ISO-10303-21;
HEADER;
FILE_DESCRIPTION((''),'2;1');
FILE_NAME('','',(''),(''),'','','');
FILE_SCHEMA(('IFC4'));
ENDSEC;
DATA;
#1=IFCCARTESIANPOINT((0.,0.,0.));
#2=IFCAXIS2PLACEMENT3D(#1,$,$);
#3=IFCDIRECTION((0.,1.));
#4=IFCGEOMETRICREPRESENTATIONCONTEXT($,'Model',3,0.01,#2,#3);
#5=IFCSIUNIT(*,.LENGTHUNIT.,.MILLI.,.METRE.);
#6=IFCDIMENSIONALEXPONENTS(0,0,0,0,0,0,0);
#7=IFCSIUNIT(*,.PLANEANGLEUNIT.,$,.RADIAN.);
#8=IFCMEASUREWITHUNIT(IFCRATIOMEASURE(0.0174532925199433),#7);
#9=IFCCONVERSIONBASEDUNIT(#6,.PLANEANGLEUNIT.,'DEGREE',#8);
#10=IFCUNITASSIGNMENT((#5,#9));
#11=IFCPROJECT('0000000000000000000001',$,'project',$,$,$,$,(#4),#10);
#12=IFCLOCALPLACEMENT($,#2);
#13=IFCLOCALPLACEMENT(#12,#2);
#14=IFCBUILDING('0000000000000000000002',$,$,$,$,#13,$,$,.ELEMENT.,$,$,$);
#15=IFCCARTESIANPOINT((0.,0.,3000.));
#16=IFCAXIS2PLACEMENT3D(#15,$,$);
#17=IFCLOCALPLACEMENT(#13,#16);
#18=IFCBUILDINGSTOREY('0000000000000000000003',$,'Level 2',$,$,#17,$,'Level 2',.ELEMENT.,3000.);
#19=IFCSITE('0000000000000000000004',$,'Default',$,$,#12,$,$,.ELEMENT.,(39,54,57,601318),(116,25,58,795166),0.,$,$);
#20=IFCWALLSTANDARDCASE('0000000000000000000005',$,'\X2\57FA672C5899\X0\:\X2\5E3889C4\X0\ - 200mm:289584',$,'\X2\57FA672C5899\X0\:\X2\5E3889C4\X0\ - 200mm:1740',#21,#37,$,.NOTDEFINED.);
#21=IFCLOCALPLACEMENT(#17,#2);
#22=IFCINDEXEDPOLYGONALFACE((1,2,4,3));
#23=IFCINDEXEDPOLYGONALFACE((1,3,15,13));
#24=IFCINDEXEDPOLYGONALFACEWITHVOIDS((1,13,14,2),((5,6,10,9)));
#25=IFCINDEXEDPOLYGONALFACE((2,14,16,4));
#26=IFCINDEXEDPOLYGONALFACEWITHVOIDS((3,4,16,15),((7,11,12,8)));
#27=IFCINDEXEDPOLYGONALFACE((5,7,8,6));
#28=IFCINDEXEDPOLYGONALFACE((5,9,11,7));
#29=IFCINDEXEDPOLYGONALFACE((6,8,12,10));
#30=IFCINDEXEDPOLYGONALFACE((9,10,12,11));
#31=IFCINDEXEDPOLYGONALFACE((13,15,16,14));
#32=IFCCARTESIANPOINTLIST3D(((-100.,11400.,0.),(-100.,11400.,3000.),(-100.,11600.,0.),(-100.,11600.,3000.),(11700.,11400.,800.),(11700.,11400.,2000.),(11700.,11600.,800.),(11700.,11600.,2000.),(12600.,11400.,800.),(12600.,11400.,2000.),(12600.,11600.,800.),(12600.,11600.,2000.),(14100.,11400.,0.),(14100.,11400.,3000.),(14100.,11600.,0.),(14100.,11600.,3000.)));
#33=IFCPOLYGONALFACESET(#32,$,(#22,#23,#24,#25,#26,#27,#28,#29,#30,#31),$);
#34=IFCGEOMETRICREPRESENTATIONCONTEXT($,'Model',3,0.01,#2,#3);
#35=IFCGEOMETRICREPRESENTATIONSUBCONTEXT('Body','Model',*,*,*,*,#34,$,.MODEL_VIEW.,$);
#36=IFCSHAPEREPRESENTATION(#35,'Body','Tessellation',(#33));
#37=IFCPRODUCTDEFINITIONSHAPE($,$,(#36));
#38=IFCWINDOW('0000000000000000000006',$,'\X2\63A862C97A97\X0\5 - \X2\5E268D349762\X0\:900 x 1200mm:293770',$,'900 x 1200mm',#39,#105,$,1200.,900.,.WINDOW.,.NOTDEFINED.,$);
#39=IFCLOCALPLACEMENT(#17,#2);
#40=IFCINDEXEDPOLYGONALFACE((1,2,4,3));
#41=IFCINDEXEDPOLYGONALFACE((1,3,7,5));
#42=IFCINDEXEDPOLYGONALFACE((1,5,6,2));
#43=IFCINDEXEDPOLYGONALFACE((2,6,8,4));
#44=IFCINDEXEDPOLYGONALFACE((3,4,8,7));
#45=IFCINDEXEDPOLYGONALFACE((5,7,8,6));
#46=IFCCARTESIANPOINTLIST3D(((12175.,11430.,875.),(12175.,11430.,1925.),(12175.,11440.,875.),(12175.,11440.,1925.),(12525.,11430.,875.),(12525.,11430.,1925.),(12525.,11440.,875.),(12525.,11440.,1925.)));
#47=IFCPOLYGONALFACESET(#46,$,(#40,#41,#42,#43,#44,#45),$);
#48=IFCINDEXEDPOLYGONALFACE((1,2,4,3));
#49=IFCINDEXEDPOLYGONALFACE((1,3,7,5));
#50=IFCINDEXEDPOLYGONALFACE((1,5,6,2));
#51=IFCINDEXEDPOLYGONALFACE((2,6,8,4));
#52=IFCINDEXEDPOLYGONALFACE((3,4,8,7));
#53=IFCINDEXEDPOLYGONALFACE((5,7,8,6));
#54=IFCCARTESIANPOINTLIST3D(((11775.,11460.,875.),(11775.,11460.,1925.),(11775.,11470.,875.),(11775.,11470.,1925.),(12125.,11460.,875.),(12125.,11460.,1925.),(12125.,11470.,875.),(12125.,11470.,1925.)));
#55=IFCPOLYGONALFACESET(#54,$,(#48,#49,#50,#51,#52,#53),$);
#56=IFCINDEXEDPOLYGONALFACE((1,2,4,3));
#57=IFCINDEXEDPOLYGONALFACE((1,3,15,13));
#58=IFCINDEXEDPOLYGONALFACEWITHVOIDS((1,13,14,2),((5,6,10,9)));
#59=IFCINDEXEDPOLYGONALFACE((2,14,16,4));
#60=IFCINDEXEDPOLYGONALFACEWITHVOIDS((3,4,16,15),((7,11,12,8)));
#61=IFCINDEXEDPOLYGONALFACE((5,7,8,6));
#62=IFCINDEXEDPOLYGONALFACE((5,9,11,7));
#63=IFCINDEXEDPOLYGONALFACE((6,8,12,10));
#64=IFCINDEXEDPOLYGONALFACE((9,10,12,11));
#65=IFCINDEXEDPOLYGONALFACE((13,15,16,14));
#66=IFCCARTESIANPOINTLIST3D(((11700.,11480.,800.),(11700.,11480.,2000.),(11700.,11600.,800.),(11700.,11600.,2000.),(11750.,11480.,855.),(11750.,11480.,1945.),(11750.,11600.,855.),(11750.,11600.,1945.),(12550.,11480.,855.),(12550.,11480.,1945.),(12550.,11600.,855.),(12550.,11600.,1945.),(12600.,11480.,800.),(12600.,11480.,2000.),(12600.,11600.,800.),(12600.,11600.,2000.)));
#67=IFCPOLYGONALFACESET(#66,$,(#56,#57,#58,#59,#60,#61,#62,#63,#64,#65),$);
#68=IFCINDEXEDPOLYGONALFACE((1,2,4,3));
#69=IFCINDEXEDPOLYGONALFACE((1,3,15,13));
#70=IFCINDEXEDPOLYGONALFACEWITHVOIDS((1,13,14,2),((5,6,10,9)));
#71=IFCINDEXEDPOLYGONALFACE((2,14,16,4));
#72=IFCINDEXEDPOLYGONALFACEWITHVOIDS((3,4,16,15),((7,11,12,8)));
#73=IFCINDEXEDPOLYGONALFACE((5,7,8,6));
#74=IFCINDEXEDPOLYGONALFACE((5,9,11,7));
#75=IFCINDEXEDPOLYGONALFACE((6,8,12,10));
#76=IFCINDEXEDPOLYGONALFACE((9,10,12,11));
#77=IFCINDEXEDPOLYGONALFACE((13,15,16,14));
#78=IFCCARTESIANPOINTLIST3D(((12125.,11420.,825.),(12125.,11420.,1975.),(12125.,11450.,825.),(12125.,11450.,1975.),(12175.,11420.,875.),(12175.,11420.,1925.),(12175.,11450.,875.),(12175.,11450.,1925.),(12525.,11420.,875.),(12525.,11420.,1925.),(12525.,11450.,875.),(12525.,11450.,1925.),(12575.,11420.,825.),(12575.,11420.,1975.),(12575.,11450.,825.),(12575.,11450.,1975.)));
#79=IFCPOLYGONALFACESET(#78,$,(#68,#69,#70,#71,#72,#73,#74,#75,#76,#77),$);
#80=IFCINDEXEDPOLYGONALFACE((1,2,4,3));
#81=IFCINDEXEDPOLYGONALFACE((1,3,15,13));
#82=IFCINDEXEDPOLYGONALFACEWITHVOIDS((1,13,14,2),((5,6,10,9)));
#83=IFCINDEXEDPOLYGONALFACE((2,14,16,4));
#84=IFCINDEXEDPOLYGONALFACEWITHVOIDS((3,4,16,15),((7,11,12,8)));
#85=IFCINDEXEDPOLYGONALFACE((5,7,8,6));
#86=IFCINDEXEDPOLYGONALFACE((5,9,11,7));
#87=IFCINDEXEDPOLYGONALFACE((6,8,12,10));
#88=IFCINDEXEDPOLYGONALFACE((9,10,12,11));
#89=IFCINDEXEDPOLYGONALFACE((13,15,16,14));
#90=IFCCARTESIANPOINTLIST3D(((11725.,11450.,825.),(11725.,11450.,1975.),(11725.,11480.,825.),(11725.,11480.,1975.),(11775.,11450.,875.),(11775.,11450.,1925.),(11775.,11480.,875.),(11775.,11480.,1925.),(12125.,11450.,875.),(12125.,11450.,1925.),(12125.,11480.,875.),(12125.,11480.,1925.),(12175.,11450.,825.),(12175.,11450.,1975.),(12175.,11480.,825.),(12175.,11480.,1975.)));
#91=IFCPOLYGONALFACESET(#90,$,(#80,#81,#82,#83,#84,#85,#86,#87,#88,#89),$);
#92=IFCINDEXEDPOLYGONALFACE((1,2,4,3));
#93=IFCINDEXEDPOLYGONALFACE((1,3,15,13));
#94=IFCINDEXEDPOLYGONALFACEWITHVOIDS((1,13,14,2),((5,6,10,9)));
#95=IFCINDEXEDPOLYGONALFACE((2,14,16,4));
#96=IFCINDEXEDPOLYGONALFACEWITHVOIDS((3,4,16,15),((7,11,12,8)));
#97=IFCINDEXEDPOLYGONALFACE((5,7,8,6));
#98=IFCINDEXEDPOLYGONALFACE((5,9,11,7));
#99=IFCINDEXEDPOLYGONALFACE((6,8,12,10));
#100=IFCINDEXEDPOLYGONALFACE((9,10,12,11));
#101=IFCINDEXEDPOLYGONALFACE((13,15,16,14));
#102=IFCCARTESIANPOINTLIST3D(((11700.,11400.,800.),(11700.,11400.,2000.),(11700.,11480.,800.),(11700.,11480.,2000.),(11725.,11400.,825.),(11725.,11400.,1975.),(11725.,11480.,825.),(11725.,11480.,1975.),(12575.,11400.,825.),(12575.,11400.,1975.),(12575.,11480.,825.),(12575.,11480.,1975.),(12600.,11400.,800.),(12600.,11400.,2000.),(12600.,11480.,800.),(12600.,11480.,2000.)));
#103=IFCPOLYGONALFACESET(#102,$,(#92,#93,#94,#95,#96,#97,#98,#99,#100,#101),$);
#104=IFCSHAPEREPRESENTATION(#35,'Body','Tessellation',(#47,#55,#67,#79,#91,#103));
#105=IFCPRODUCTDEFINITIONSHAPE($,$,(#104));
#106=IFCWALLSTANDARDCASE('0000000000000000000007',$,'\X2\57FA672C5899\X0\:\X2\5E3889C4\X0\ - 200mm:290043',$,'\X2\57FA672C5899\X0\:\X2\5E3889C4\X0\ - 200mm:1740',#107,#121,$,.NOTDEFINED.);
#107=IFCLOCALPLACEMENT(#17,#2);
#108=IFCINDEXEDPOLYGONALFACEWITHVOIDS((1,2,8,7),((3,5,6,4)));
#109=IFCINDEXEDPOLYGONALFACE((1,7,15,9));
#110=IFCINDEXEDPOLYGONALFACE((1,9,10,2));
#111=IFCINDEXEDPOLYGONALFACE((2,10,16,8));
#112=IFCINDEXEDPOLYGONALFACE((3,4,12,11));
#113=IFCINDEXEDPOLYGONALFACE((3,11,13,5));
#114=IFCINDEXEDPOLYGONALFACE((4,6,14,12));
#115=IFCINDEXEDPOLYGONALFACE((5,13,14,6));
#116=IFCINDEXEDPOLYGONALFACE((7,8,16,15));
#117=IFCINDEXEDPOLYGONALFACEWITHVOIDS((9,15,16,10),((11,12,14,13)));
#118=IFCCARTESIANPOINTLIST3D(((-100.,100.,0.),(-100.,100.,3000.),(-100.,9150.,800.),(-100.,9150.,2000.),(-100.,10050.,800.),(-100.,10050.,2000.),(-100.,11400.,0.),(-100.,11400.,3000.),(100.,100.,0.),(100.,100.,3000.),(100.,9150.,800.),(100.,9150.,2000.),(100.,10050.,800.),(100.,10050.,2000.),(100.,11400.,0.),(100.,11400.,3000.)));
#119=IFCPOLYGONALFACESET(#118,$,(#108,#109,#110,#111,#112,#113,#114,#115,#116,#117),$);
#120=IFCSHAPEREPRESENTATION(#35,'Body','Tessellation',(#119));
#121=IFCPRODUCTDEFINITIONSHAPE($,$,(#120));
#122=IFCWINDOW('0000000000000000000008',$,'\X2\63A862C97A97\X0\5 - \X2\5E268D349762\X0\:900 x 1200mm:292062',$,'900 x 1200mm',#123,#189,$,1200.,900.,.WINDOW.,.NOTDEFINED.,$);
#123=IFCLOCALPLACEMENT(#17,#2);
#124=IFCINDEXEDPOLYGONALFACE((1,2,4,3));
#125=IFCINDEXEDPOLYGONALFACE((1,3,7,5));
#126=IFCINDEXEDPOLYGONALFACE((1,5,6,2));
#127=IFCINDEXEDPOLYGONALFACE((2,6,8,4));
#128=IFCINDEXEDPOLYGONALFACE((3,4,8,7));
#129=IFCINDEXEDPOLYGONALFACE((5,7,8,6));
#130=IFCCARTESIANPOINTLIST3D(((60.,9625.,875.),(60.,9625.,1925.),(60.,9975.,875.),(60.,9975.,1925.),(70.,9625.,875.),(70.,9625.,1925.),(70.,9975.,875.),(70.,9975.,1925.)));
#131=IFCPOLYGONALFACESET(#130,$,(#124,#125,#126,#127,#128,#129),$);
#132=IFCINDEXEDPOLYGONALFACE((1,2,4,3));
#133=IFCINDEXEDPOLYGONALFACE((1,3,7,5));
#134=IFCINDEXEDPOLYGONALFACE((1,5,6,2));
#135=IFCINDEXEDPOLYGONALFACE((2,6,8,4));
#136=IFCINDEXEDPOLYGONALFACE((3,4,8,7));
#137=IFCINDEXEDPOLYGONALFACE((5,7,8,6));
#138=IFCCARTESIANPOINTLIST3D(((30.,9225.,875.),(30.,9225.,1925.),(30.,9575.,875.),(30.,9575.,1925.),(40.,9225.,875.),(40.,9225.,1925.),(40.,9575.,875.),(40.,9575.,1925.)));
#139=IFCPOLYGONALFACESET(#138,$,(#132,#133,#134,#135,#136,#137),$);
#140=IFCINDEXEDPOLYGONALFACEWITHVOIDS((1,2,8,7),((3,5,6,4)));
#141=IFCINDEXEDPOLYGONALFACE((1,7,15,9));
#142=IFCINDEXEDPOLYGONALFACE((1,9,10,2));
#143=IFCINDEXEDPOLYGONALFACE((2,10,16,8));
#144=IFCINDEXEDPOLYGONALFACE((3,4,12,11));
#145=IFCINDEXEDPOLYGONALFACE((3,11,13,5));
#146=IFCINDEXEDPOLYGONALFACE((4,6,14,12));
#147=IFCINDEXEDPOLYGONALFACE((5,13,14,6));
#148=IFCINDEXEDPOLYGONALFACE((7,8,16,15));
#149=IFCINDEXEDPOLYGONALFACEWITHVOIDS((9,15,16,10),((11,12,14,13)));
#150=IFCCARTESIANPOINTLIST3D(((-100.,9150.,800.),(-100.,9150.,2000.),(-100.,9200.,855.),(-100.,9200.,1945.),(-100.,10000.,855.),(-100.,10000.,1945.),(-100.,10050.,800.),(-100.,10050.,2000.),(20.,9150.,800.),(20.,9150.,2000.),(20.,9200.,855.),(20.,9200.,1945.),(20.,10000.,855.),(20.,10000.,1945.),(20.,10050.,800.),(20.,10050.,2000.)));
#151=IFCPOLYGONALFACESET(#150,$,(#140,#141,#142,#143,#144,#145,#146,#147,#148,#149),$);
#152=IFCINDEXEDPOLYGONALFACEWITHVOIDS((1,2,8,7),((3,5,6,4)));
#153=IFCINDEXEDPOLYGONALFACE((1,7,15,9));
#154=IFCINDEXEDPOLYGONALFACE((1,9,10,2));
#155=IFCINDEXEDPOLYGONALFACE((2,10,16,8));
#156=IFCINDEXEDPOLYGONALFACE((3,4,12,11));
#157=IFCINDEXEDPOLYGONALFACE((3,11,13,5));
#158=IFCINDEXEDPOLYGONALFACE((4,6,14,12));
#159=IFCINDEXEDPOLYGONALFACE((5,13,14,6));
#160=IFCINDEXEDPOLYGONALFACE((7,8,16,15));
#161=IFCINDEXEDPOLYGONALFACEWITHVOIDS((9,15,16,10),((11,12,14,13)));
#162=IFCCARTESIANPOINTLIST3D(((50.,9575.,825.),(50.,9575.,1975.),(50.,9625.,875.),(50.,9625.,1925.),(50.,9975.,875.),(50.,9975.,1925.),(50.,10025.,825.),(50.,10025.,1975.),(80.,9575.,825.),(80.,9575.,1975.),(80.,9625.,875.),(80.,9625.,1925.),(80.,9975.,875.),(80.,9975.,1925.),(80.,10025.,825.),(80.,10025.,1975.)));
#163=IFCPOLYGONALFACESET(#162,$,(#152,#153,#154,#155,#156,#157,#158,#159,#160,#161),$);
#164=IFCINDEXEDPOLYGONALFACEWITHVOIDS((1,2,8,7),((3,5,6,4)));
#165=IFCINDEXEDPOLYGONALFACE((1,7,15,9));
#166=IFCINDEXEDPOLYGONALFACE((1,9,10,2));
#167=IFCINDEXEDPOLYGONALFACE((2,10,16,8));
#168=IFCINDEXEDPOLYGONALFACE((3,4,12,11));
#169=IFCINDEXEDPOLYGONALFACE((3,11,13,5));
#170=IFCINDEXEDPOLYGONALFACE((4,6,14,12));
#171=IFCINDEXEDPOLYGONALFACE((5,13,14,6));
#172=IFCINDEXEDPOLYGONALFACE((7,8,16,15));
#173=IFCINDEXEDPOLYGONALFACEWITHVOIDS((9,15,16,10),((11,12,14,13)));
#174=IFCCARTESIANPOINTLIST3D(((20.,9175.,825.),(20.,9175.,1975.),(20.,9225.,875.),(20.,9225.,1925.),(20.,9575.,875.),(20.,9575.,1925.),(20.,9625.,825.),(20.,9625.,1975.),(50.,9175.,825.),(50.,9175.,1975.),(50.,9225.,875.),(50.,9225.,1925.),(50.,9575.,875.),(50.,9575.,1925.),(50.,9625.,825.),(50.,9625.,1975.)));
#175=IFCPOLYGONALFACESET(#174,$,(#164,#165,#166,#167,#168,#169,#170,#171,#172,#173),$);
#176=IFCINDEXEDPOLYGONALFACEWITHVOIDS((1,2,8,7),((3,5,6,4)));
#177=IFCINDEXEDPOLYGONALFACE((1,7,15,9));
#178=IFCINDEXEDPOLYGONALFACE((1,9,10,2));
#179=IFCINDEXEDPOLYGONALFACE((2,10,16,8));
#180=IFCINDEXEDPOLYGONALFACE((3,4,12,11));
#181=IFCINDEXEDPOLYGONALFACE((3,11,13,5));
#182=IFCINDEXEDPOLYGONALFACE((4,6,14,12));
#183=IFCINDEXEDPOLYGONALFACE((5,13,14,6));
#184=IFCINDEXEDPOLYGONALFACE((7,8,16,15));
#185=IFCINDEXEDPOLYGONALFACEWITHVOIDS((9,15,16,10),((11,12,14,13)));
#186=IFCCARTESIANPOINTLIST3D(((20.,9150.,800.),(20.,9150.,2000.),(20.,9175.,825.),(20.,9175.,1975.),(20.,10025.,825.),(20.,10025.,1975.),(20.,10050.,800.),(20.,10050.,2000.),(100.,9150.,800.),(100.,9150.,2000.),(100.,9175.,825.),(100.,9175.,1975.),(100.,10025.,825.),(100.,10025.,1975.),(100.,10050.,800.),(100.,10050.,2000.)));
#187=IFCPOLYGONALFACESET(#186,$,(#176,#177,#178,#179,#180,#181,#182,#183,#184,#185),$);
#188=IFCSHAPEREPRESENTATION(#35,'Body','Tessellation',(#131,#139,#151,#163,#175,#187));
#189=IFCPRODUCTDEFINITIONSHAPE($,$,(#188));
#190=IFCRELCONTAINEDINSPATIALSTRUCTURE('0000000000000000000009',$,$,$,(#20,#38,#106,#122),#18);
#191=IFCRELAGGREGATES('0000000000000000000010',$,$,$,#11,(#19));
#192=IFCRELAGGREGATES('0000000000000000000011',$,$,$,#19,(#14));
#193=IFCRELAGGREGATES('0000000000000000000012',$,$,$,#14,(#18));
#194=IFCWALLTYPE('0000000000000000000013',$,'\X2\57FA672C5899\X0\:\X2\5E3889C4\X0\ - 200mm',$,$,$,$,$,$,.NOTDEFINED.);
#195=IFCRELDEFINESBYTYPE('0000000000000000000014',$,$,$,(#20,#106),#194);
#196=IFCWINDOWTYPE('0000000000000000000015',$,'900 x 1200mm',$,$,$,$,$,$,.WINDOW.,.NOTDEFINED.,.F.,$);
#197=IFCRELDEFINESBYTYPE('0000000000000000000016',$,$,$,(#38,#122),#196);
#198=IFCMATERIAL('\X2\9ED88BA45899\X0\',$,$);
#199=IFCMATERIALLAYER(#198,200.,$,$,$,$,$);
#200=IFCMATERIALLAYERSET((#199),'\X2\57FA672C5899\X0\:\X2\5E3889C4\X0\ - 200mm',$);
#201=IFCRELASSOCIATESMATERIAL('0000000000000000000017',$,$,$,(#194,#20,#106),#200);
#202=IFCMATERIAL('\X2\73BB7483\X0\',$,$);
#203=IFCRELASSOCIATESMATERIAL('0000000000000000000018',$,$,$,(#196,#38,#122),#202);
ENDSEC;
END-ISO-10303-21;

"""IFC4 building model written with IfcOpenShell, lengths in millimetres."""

from ifc_helpers import new_model, entity, si_unit, converted_unit, direction, frame, frame_2d, origin, origin_2d_with_axis, place, context, subcontext, project, spatial, polyline, rectangle, outline, extrude, source, transform, mapped, material, layer, layer_set, layer_usage, type_object, type_shapes, element, fill, save


model = new_model("IFC4")

# Units and contexts
model_context_1 = context("Model", 3, precision=0.01, world=origin(), true_north=direction((0.0, 1.0)))
model_context_2 = context("Model", 3, precision=0.01, world=origin(), true_north=direction((0.0, 1.0)))
body_context = subcontext(model_context_2, "Body", "Model", "MODEL_VIEW")
ifc_project = project(units=[si_unit("LENGTHUNIT", "METRE", prefix="MILLI"), converted_unit("PLANEANGLEUNIT", "DEGREE", entity("IfcRatioMeasure", 0.0174532925199433), si_unit("PLANEANGLEUNIT", "RADIAN"), dimensions=[0, 0, 0, 0, 0, 0, 0])], contexts=[model_context_1])

# Site, building, storey
site_placement = place(None, origin())
site = spatial("IfcSite", under=ifc_project, at=site_placement, Name="Default", CompositionType="ELEMENT", RefLatitude=(39, 54, 57, 601318), RefLongitude=(116, 25, 58, 795166), RefElevation=0.0)
building_placement = place(site_placement, origin())
building = spatial("IfcBuilding", under=site, at=building_placement, CompositionType="ELEMENT")
storey_placement = place(building_placement, frame((0.0, 0.0, 3000.0)))
storey = spatial("IfcBuildingStorey", under=building, at=storey_placement, Name="Level 2", LongName="Level 2", CompositionType="ELEMENT", Elevation=3000.0)

# Walls, openings, windows
ifc_material_1 = material(Name="默认墙")
ifc_layer_1 = layer(ifc_material_1, 200.0)
ifc_layer_set_1 = layer_set([ifc_layer_1], Name="基本墙:常规 - 200mm")
ifc_layer_usage_1 = layer_usage(ifc_layer_set_1, "AXIS2", "NEGATIVE", 100.0)
wall_type = type_object("IfcWallType", Name="基本墙:常规 - 200mm", PredefinedType="NOTDEFINED", material=ifc_layer_set_1)
wall_1_placement = place(storey_placement, frame((-100.0, 11500.0, 0.0)))
wall_1 = element("IfcWallStandardCase", 1, at=wall_1_placement, inside=storey, type_object=wall_type, material=ifc_layer_usage_1, Name="基本墙:常规 - 200mm:289584", ObjectType="基本墙:常规 - 200mm:1740", PredefinedType="NOTDEFINED", context=body_context, shape_type="SweptSolid", body=[
    extrude(rectangle(XDim=14200.0, YDim=200.0, at=frame_2d((7100.0, 0.0), x_axis=(-1.0, 0.0))), origin(), (0.0, 0.0, 1.0), 3000.0),
])
opening_1_placement = place(wall_1_placement, frame((12700.0, 100.0, 800.0)))
opening_1 = element("IfcOpeningElement", 2, at=opening_1_placement, cuts=wall_1, ObjectType="Opening", PredefinedType="OPENING", context=body_context, shape_type="SweptSolid", body=[
    extrude(rectangle(XDim=1200.0, YDim=900.0, at=frame_2d((600.0, 450.0), x_axis=(-1.0, 0.0))), frame((0.0, 0.0, 0.0), z_axis=(0.0, -1.0, 0.0), x_axis=(0.0, 0.0, 1.0)), (0.0, 0.0, 1.0), 200.0),
])
ifc_material_2 = material(Name="玻璃")
window_type = type_object("IfcWindowType", Name="900 x 1200mm", ParameterTakesPrecedence=False, PartitioningType="NOTDEFINED", PredefinedType="WINDOW", material=ifc_material_2)
shared_shape_1 = source(origin(), body_context, "Body", "SweptSolid", [
    extrude(rectangle(XDim=10.0, YDim=350.0, at=origin_2d_with_axis()), frame((250.0, 165.0, 75.0), z_axis=(0.0, 0.0, 1.0), x_axis=(0.0, -1.0, 0.0)), (0.0, 0.0, 1.0), 1050.0),
    extrude(rectangle(XDim=10.0, YDim=350.0, at=origin_2d_with_axis()), frame((650.0, 135.0, 75.0), z_axis=(0.0, 0.0, 1.0), x_axis=(0.0, -1.0, 0.0)), (0.0, 0.0, 1.0), 1050.0),
    extrude(outline(polyline([(-450.0, -600.0), (450.0, -600.0), (450.0, 600.0), (-450.0, 600.0), (-450.0, -600.0)]), holes=[polyline([(400.0, -545.0), (-400.0, -545.0), (-400.0, 545.0), (400.0, 545.0), (400.0, -545.0)])]), frame((450.0, 0.0, 600.0), z_axis=(0.0, 1.0, 0.0), x_axis=(1.0, 0.0, 0.0)), (0.0, 0.0, 1.0), 120.0),
    extrude(outline(polyline([(-225.0, -575.0), (225.0, -575.0), (225.0, 575.0), (-225.0, 575.0), (-225.0, -575.0)]), holes=[polyline([(-175.0, -525.0), (-175.0, 525.0), (175.0, 525.0), (175.0, -525.0), (-175.0, -525.0)])]), frame((250.0, 150.0, 600.0), z_axis=(0.0, 1.0, 0.0), x_axis=(-1.0, 0.0, 0.0)), (0.0, 0.0, 1.0), 30.0),
    extrude(outline(polyline([(-225.0, -575.0), (225.0, -575.0), (225.0, 575.0), (-225.0, 575.0), (-225.0, -575.0)]), holes=[polyline([(-175.0, -525.0), (-175.0, 525.0), (175.0, 525.0), (175.0, -525.0), (-175.0, -525.0)])]), frame((650.0, 120.0, 600.0), z_axis=(0.0, 1.0, 0.0), x_axis=(1.0, 0.0, 0.0)), (0.0, 0.0, 1.0), 30.0),
    extrude(outline(polyline([(-450.0, -600.0), (450.0, -600.0), (450.0, 600.0), (-450.0, 600.0), (-450.0, -600.0)]), holes=[polyline([(-425.0, 575.0), (425.0, 575.0), (425.0, -575.0), (-425.0, -575.0), (-425.0, 575.0)])]), frame((450.0, 120.0, 600.0), z_axis=(0.0, 1.0, 0.0), x_axis=(1.0, 0.0, 0.0)), (0.0, 0.0, 1.0), 80.0),
])
type_shapes(window_type, [shared_shape_1])
window_1_placement = place(opening_1_placement, frame((0.0, 0.0, 0.0), z_axis=(0.0, 0.0, 1.0), x_axis=(-1.0, 0.0, 0.0)))
window_1 = element("IfcWindow", 3, at=window_1_placement, inside=storey, type_object=window_type, material=ifc_material_2, Name="推拉窗5 - 带贴面:900 x 1200mm:293770", ObjectType="900 x 1200mm", OverallHeight=1200.0, OverallWidth=900.0, PartitioningType="NOTDEFINED", PredefinedType="WINDOW", context=body_context, shape_type="MappedRepresentation", body=[
    mapped(shared_shape_1, transform((0.0, 0.0, 0.0), scale=1.0)),
])
fill(opening_1, window_1)
ifc_layer_usage_2 = layer_usage(ifc_layer_set_1, "AXIS2", "NEGATIVE", 100.0)
wall_2_placement = place(storey_placement, frame((0.0, 100.0, 0.0), z_axis=(0.0, 0.0, 1.0), x_axis=(0.0, 1.0, 0.0)))
wall_2 = element("IfcWallStandardCase", 4, at=wall_2_placement, inside=storey, type_object=wall_type, material=ifc_layer_usage_2, Name="基本墙:常规 - 200mm:290043", ObjectType="基本墙:常规 - 200mm:1740", PredefinedType="NOTDEFINED", context=body_context, shape_type="SweptSolid", body=[
    extrude(rectangle(XDim=11300.0, YDim=200.0, at=frame_2d((5650.0, 0.0), x_axis=(-1.0, 0.0))), origin(), (0.0, 0.0, 1.0), 3000.0),
])
opening_2_placement = place(wall_2_placement, frame((9950.0, 100.0, 800.0)))
opening_2 = element("IfcOpeningElement", 5, at=opening_2_placement, cuts=wall_2, ObjectType="Opening", PredefinedType="OPENING", context=body_context, shape_type="SweptSolid", body=[
    extrude(rectangle(XDim=1200.0, YDim=900.0, at=frame_2d((600.0, 450.0), x_axis=(-1.0, 0.0))), frame((0.0, 0.0, 0.0), z_axis=(0.0, -1.0, 0.0), x_axis=(0.0, 0.0, 1.0)), (0.0, 0.0, 1.0), 200.0),
])
window_2_placement = place(opening_2_placement, frame((0.0, 0.0, 0.0), z_axis=(0.0, 0.0, 1.0), x_axis=(-1.0, 0.0, 0.0)))
window_2 = element("IfcWindow", 6, at=window_2_placement, inside=storey, type_object=window_type, material=ifc_material_2, Name="推拉窗5 - 带贴面:900 x 1200mm:292062", ObjectType="900 x 1200mm", OverallHeight=1200.0, OverallWidth=900.0, PartitioningType="NOTDEFINED", PredefinedType="WINDOW", context=body_context, shape_type="MappedRepresentation", body=[
    mapped(shared_shape_1, transform((0.0, 0.0, 0.0), scale=1.0)),
])
fill(opening_2, window_2)

save(model, "model.ifc")
